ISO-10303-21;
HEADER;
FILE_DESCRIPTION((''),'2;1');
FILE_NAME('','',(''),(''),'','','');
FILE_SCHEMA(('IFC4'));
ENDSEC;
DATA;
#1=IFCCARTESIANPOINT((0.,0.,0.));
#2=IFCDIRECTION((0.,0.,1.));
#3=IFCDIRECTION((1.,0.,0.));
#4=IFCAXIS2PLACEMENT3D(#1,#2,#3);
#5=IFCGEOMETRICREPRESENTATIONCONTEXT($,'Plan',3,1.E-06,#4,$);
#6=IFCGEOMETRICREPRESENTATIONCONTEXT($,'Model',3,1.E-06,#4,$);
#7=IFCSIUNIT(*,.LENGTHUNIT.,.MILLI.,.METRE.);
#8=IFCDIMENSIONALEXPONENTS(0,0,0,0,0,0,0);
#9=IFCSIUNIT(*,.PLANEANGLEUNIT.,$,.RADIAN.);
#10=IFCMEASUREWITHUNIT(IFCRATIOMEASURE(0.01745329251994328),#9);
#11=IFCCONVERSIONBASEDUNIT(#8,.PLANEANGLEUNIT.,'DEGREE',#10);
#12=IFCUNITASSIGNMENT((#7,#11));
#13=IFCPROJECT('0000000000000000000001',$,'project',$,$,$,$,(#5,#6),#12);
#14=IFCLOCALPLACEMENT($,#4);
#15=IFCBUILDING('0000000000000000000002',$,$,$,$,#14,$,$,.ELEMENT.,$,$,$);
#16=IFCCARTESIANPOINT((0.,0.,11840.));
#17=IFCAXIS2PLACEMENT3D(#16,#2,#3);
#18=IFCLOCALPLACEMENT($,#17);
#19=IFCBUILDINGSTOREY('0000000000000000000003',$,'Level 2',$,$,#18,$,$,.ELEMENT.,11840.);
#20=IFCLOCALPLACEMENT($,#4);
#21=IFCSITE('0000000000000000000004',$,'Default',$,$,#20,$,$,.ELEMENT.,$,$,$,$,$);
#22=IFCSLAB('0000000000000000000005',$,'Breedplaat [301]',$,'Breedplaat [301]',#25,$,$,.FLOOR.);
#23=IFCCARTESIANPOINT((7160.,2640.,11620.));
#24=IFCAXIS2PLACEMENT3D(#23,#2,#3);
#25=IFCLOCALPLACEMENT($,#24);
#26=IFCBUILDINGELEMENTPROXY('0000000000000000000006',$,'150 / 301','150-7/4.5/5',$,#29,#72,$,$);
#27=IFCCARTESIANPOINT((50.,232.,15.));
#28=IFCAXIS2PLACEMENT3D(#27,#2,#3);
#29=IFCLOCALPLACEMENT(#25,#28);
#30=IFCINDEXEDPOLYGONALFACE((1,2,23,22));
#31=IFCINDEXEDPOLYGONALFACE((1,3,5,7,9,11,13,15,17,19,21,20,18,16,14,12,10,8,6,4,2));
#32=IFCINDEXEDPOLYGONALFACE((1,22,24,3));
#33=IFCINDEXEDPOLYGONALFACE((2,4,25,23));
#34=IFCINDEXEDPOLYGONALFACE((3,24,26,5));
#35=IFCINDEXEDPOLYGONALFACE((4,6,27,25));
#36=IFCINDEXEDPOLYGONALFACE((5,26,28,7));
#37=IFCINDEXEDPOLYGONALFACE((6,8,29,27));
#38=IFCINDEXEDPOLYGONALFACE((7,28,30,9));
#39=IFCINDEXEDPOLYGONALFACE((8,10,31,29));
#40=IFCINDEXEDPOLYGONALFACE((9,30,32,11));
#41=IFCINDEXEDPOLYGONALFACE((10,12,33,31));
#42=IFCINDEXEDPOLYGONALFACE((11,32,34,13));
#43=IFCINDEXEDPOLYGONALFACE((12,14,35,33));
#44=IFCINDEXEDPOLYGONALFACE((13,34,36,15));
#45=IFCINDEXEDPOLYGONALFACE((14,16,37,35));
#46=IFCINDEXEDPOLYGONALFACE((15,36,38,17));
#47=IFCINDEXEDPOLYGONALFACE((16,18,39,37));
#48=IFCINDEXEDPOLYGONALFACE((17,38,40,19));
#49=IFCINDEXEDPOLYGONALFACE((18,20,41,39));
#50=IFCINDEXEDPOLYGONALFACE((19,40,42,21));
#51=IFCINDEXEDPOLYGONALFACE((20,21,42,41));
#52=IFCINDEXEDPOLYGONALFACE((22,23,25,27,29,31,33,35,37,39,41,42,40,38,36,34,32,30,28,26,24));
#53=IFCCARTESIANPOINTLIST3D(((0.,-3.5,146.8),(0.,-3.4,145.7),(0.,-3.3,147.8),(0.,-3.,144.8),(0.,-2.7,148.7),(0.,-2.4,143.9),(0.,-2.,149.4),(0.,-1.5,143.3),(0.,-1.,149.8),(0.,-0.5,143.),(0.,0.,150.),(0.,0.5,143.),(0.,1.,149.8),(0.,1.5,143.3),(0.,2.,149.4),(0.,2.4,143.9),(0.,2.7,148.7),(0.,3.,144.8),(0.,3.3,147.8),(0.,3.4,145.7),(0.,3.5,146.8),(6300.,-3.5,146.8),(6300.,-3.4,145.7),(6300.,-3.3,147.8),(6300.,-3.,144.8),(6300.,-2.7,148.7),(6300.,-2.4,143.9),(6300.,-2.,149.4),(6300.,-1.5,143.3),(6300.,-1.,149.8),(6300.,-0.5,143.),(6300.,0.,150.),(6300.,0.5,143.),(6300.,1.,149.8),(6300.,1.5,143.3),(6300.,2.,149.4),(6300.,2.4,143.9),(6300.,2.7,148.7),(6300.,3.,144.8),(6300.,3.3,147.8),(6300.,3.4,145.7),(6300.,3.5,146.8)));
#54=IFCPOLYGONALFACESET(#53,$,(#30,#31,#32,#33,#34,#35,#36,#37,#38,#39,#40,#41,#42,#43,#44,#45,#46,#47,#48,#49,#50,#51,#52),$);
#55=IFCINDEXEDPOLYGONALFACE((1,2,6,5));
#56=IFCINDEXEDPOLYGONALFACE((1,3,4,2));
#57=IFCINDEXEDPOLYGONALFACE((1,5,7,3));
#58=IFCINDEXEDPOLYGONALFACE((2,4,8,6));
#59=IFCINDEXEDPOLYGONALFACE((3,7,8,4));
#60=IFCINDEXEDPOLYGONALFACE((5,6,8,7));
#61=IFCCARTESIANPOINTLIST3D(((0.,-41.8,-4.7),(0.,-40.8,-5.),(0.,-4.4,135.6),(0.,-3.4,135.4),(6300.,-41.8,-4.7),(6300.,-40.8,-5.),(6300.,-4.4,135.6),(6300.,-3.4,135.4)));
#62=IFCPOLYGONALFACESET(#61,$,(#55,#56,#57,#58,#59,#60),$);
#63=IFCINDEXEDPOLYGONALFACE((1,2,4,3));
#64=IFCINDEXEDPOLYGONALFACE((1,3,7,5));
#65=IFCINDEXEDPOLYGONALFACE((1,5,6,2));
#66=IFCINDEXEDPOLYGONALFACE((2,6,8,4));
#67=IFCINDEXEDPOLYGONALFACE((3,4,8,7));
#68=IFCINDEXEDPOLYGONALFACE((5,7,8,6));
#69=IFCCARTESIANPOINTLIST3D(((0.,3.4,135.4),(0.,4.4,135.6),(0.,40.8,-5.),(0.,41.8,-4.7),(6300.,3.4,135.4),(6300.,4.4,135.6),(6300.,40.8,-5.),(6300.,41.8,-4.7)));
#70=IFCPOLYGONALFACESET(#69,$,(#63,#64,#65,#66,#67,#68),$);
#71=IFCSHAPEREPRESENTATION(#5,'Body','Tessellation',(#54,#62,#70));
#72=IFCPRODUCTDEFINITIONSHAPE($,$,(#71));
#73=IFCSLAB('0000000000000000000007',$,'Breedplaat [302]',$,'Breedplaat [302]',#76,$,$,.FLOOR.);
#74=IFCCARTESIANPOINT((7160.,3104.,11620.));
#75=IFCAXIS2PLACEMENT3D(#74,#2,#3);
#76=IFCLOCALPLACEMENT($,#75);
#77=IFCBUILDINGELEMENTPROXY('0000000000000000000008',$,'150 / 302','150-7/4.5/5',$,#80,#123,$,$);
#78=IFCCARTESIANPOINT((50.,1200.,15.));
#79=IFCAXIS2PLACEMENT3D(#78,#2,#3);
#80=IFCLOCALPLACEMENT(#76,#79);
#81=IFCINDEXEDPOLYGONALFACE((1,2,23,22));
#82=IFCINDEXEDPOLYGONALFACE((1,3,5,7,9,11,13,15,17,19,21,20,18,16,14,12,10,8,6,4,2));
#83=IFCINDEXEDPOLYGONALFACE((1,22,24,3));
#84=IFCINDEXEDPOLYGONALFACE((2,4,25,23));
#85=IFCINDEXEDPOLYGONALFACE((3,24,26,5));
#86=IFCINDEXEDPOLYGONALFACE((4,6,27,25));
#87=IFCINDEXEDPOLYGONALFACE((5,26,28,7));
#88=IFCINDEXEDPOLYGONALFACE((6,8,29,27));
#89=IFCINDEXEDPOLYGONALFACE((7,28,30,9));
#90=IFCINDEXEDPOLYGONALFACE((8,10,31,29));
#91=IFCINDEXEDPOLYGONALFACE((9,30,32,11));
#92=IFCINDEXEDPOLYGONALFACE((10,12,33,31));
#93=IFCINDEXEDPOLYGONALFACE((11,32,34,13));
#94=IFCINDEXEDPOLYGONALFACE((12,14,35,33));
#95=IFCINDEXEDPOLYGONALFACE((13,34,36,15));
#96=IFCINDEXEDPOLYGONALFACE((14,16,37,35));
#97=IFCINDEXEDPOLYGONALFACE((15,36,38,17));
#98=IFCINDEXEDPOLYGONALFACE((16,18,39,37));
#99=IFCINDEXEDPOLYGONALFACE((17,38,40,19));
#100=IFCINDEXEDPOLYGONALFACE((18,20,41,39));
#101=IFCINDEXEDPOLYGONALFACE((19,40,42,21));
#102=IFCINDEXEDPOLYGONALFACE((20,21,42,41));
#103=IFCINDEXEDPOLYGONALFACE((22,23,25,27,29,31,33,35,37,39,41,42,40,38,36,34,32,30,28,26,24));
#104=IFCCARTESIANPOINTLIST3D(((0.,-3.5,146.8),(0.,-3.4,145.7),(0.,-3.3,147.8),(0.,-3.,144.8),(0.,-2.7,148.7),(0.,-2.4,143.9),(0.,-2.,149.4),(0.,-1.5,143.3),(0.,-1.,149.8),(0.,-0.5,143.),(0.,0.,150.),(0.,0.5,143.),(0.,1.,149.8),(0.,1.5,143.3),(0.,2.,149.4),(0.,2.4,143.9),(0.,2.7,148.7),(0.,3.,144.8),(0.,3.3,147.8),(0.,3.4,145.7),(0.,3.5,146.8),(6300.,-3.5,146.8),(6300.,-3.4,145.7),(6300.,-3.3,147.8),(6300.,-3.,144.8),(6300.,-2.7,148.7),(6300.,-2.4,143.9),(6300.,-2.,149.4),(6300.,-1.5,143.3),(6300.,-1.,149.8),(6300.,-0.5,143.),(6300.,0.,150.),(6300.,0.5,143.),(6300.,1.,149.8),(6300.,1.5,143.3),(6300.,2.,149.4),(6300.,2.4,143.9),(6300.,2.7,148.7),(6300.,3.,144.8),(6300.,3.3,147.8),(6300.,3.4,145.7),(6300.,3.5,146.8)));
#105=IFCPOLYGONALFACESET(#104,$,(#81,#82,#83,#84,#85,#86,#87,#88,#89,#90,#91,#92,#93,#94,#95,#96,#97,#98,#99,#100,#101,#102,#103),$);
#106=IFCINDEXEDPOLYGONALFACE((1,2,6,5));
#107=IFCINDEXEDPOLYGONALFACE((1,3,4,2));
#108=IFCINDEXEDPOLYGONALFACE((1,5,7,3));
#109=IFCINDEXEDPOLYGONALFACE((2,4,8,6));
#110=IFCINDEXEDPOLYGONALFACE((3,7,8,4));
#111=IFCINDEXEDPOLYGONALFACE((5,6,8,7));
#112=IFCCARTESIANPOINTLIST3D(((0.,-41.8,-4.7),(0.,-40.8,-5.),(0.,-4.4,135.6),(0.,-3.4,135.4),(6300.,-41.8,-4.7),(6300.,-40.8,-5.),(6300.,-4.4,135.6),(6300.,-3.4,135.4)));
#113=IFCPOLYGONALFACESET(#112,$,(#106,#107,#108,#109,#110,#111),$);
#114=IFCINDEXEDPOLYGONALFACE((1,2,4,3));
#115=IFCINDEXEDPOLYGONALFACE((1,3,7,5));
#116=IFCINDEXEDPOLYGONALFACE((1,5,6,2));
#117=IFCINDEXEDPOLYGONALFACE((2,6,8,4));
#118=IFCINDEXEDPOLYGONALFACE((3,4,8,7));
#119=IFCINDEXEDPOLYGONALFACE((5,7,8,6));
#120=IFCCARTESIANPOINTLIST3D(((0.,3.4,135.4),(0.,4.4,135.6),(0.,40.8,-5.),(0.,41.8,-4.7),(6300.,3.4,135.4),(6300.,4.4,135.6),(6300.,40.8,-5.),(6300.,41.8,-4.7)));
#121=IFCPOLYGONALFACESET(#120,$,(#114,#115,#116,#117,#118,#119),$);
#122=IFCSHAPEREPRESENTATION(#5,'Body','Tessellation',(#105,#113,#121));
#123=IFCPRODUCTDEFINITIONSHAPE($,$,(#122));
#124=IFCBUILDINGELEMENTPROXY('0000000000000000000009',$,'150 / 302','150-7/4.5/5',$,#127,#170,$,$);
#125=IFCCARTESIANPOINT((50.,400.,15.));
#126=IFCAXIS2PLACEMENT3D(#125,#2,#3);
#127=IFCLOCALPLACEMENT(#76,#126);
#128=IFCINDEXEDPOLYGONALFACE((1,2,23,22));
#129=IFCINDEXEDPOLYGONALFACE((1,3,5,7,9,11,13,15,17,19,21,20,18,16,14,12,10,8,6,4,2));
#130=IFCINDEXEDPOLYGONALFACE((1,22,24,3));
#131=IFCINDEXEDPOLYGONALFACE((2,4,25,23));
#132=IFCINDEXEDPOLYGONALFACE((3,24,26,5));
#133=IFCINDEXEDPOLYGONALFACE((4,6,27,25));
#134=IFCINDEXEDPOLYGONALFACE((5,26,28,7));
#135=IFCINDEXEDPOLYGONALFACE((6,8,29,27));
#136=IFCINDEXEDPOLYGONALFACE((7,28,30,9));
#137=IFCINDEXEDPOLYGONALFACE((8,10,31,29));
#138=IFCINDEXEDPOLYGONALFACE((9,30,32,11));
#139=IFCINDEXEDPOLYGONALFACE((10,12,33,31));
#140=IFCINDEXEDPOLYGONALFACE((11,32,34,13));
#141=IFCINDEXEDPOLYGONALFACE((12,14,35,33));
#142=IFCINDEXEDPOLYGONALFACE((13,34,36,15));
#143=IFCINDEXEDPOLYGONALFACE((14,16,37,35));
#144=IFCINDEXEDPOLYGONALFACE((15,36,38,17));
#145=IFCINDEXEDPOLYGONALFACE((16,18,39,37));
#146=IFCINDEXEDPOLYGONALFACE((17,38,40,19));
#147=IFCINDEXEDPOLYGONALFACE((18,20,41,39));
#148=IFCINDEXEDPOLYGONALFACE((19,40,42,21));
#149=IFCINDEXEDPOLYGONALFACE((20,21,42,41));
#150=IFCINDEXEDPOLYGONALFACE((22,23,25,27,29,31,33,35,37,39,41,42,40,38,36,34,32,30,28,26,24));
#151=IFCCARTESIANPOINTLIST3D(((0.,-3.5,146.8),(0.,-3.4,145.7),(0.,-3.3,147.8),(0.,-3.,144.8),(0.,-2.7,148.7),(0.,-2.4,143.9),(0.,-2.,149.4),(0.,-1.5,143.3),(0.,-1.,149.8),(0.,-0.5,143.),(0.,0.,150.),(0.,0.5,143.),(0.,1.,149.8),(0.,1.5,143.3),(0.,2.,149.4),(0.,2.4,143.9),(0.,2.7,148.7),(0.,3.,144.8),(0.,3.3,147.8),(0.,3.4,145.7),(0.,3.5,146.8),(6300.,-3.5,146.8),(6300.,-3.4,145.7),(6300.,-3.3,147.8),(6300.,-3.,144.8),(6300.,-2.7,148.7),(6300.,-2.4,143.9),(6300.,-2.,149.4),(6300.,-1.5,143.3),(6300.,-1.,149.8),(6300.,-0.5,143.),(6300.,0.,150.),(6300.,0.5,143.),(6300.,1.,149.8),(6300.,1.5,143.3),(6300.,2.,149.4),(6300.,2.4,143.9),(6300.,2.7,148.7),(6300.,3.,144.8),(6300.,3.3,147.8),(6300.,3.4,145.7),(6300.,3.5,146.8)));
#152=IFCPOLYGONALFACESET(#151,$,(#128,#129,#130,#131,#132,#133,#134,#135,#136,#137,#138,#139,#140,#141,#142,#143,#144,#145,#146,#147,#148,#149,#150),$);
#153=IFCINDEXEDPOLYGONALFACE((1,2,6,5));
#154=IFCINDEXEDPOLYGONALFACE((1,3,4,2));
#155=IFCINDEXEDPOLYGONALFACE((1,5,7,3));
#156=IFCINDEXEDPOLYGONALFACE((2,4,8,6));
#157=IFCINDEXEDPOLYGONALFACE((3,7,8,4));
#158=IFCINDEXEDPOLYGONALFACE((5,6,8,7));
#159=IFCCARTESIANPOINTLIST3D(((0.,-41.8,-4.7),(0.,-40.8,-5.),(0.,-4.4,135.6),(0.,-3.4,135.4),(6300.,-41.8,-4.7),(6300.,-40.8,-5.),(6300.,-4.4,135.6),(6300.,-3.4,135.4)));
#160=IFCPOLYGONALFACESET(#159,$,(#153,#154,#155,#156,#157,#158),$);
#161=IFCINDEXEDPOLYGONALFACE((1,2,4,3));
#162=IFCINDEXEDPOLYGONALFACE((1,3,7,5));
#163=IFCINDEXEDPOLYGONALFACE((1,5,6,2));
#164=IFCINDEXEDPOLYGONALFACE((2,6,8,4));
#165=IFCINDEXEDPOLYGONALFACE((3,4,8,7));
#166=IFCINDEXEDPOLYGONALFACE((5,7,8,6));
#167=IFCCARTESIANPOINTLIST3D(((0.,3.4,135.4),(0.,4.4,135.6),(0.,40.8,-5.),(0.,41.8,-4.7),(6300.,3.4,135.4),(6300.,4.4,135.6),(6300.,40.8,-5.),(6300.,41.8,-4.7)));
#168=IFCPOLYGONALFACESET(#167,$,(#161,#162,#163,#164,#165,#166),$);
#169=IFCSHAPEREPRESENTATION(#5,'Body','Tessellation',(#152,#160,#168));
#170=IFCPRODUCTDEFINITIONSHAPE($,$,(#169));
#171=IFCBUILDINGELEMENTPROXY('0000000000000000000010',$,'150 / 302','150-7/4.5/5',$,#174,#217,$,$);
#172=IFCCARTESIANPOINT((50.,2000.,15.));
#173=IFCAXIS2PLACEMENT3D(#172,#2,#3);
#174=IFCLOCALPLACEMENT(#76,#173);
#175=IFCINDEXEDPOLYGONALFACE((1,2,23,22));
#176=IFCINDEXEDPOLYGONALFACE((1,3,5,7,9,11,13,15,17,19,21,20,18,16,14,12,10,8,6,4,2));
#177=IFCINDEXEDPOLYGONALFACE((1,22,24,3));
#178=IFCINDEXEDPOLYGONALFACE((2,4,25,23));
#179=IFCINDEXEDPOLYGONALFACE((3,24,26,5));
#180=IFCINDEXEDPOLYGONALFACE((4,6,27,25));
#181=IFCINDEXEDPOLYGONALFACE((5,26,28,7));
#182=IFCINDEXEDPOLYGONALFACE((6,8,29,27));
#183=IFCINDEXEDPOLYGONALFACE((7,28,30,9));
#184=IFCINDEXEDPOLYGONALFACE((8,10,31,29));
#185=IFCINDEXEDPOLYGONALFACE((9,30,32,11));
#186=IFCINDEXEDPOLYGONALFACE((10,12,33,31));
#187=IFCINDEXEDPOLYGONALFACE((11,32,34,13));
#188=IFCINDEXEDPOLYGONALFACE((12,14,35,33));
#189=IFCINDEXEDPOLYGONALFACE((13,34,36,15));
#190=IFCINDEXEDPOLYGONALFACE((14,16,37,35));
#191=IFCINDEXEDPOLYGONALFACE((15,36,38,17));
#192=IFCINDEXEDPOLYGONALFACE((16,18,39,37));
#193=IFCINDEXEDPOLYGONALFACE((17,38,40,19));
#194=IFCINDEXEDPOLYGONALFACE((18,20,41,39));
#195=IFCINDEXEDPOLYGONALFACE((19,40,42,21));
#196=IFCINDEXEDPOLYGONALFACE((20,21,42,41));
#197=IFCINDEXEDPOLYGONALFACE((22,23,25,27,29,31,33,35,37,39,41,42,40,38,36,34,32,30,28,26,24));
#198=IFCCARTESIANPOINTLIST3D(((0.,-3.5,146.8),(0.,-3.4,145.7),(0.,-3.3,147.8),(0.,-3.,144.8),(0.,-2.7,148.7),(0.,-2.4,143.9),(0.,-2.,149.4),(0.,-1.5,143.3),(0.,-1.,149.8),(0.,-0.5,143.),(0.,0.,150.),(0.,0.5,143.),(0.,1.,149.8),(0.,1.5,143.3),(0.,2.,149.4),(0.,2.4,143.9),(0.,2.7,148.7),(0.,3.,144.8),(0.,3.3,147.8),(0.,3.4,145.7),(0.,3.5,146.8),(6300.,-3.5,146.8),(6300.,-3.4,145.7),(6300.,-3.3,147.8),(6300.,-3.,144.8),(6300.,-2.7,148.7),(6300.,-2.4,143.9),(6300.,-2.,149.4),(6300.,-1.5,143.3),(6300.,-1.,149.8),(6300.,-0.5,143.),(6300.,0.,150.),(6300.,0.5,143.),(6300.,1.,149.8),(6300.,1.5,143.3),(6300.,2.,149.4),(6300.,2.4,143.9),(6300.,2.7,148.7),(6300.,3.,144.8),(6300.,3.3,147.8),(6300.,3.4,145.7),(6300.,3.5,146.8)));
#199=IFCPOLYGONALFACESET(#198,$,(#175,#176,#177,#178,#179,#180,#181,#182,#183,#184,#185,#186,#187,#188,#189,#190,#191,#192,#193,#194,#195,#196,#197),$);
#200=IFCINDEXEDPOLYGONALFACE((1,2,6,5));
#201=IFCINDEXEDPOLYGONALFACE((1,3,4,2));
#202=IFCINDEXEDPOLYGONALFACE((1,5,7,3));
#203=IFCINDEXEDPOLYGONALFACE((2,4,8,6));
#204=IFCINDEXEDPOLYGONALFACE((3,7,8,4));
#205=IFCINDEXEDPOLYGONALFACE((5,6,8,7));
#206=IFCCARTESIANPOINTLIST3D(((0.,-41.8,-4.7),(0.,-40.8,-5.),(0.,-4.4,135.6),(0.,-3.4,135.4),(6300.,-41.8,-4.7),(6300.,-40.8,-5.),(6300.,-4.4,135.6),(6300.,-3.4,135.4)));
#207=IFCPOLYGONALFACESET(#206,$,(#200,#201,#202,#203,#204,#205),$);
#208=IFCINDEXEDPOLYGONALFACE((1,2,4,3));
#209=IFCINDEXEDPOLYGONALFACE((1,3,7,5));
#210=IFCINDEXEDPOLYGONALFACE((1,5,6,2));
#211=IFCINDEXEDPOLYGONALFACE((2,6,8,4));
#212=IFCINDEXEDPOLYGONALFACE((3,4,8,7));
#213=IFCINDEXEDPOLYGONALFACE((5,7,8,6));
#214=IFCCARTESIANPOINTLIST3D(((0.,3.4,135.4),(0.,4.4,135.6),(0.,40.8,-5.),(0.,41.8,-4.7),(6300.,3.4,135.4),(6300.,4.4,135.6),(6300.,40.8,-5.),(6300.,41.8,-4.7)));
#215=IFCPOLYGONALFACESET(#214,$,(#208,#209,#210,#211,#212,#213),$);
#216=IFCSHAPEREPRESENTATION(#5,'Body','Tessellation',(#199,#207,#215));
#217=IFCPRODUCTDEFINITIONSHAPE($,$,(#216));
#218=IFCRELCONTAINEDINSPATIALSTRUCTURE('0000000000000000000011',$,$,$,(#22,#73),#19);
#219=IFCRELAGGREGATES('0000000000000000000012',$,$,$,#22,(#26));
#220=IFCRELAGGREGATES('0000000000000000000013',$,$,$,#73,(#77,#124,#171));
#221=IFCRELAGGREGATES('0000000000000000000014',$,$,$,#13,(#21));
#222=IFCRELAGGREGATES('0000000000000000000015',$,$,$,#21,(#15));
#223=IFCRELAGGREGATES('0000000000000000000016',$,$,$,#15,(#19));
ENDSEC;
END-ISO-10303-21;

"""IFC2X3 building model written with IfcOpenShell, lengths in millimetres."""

from ifc_helpers import new_model, entity, si_unit, converted_unit, frame, origin_with_axes, origin_2d_with_axis, place, context, project, spatial, rectangle, circle, extrude, element, aggregate, save


model = new_model("IFC2X3")

# Units and contexts
plan_context = context("Plan", 3, precision=1e-06, world=origin_with_axes())
model_context = context("Model", 3, precision=1e-06, world=origin_with_axes())
ifc_project = project(units=[si_unit("LENGTHUNIT", "METRE", prefix="MILLI"), converted_unit("PLANEANGLEUNIT", "DEGREE", entity("IfcRatioMeasure", 0.01745329251994328), si_unit("PLANEANGLEUNIT", "RADIAN"), dimensions=[0, 0, 0, 0, 0, 0, 0])], contexts=[plan_context, model_context])

# Site, building, storey
site_placement = place(None, origin_with_axes())
site = spatial("IfcSite", under=ifc_project, at=site_placement, Name="Default", CompositionType="ELEMENT")
building_placement = place(None, origin_with_axes())
building = spatial("IfcBuilding", under=site, at=building_placement, CompositionType="ELEMENT")
storey_placement = place(None, frame((0.0, 0.0, 11840.0), z_axis=(0.0, 0.0, 1.0), x_axis=(1.0, 0.0, 0.0)))
storey = spatial("IfcBuildingStorey", under=building, at=storey_placement, Name="Level 2", CompositionType="ELEMENT", Elevation=11840.0)

# Slab, building element proxy
slab_1_placement = place(None, frame((7160.0, 2640.0, 11620.0), z_axis=(0.0, 0.0, 1.0), x_axis=(1.0, 0.0, 0.0)))
slab_1 = element("IfcSlab", 1, at=slab_1_placement, inside=storey, Name="Breedplaat [301]", ObjectType="Breedplaat [301]", PredefinedType="FLOOR")
proxy_1_placement = place(slab_1_placement, frame((50.0, 232.0, 15.0), z_axis=(0.0, 0.0, 1.0), x_axis=(1.0, 0.0, 0.0)))
proxy_1 = element("IfcBuildingElementProxy", 2, at=proxy_1_placement, Name="150 / 301", Description="150-7/4.5/5", context=plan_context, shape_type="SweptSolid", body=[
    extrude(circle(Radius=3.5, at=origin_2d_with_axis()), frame((0.0, 0.0, 146.5), z_axis=(1.0, 0.0, 0.0), x_axis=(0.0, 0.0, 1.0)), (0.0, 0.0, 1.0), 6300.0),
    extrude(rectangle(XDim=145.2, YDim=1.0, at=origin_2d_with_axis()), frame((0.0, -22.6, 65.3), z_axis=(1.0, 0.0, 0.0), x_axis=(0.0, 0.257663, 0.966235)), (0.0, 0.0, 1.0), 6300.0),
    extrude(rectangle(XDim=145.2, YDim=1.0, at=origin_2d_with_axis()), frame((0.0, 22.6, 65.3), z_axis=(1.0, 0.0, 0.0), x_axis=(0.0, -0.257663, 0.966235)), (0.0, 0.0, 1.0), 6300.0),
])
aggregate(slab_1, [proxy_1])

# Slab, building element proxies
slab_2_placement = place(None, frame((7160.0, 3104.0, 11620.0), z_axis=(0.0, 0.0, 1.0), x_axis=(1.0, 0.0, 0.0)))
slab_2 = element("IfcSlab", 3, at=slab_2_placement, inside=storey, Name="Breedplaat [302]", ObjectType="Breedplaat [302]", PredefinedType="FLOOR")
proxy_2_placement = place(slab_2_placement, frame((50.0, 1200.0, 15.0), z_axis=(0.0, 0.0, 1.0), x_axis=(1.0, 0.0, 0.0)))
proxy_2 = element("IfcBuildingElementProxy", 4, at=proxy_2_placement, Name="150 / 302", Description="150-7/4.5/5", context=plan_context, shape_type="SweptSolid", body=[
    extrude(circle(Radius=3.5, at=origin_2d_with_axis()), frame((0.0, 0.0, 146.5), z_axis=(1.0, 0.0, 0.0), x_axis=(0.0, 0.0, 1.0)), (0.0, 0.0, 1.0), 6300.0),
    extrude(rectangle(XDim=145.2, YDim=1.0, at=origin_2d_with_axis()), frame((0.0, -22.6, 65.3), z_axis=(1.0, 0.0, 0.0), x_axis=(0.0, 0.257663, 0.966235)), (0.0, 0.0, 1.0), 6300.0),
    extrude(rectangle(XDim=145.2, YDim=1.0, at=origin_2d_with_axis()), frame((0.0, 22.6, 65.3), z_axis=(1.0, 0.0, 0.0), x_axis=(0.0, -0.257663, 0.966235)), (0.0, 0.0, 1.0), 6300.0),
])
proxy_3_placement = place(slab_2_placement, frame((50.0, 400.0, 15.0), z_axis=(0.0, 0.0, 1.0), x_axis=(1.0, 0.0, 0.0)))
proxy_3 = element("IfcBuildingElementProxy", 5, at=proxy_3_placement, Name="150 / 302", Description="150-7/4.5/5", context=plan_context, shape_type="SweptSolid", body=[
    extrude(circle(Radius=3.5, at=origin_2d_with_axis()), frame((0.0, 0.0, 146.5), z_axis=(1.0, 0.0, 0.0), x_axis=(0.0, 0.0, 1.0)), (0.0, 0.0, 1.0), 6300.0),
    extrude(rectangle(XDim=145.2, YDim=1.0, at=origin_2d_with_axis()), frame((0.0, -22.6, 65.3), z_axis=(1.0, 0.0, 0.0), x_axis=(0.0, 0.257663, 0.966235)), (0.0, 0.0, 1.0), 6300.0),
    extrude(rectangle(XDim=145.2, YDim=1.0, at=origin_2d_with_axis()), frame((0.0, 22.6, 65.3), z_axis=(1.0, 0.0, 0.0), x_axis=(0.0, -0.257663, 0.966235)), (0.0, 0.0, 1.0), 6300.0),
])
proxy_4_placement = place(slab_2_placement, frame((50.0, 2000.0, 15.0), z_axis=(0.0, 0.0, 1.0), x_axis=(1.0, 0.0, 0.0)))
proxy_4 = element("IfcBuildingElementProxy", 6, at=proxy_4_placement, Name="150 / 302", Description="150-7/4.5/5", context=plan_context, shape_type="SweptSolid", body=[
    extrude(circle(Radius=3.5, at=origin_2d_with_axis()), frame((0.0, 0.0, 146.5), z_axis=(1.0, 0.0, 0.0), x_axis=(0.0, 0.0, 1.0)), (0.0, 0.0, 1.0), 6300.0),
    extrude(rectangle(XDim=145.2, YDim=1.0, at=origin_2d_with_axis()), frame((0.0, -22.6, 65.3), z_axis=(1.0, 0.0, 0.0), x_axis=(0.0, 0.257663, 0.966235)), (0.0, 0.0, 1.0), 6300.0),
    extrude(rectangle(XDim=145.2, YDim=1.0, at=origin_2d_with_axis()), frame((0.0, 22.6, 65.3), z_axis=(1.0, 0.0, 0.0), x_axis=(0.0, -0.257663, 0.966235)), (0.0, 0.0, 1.0), 6300.0),
])
aggregate(slab_2, [proxy_2, proxy_3, proxy_4])

save(model, "model.ifc")
